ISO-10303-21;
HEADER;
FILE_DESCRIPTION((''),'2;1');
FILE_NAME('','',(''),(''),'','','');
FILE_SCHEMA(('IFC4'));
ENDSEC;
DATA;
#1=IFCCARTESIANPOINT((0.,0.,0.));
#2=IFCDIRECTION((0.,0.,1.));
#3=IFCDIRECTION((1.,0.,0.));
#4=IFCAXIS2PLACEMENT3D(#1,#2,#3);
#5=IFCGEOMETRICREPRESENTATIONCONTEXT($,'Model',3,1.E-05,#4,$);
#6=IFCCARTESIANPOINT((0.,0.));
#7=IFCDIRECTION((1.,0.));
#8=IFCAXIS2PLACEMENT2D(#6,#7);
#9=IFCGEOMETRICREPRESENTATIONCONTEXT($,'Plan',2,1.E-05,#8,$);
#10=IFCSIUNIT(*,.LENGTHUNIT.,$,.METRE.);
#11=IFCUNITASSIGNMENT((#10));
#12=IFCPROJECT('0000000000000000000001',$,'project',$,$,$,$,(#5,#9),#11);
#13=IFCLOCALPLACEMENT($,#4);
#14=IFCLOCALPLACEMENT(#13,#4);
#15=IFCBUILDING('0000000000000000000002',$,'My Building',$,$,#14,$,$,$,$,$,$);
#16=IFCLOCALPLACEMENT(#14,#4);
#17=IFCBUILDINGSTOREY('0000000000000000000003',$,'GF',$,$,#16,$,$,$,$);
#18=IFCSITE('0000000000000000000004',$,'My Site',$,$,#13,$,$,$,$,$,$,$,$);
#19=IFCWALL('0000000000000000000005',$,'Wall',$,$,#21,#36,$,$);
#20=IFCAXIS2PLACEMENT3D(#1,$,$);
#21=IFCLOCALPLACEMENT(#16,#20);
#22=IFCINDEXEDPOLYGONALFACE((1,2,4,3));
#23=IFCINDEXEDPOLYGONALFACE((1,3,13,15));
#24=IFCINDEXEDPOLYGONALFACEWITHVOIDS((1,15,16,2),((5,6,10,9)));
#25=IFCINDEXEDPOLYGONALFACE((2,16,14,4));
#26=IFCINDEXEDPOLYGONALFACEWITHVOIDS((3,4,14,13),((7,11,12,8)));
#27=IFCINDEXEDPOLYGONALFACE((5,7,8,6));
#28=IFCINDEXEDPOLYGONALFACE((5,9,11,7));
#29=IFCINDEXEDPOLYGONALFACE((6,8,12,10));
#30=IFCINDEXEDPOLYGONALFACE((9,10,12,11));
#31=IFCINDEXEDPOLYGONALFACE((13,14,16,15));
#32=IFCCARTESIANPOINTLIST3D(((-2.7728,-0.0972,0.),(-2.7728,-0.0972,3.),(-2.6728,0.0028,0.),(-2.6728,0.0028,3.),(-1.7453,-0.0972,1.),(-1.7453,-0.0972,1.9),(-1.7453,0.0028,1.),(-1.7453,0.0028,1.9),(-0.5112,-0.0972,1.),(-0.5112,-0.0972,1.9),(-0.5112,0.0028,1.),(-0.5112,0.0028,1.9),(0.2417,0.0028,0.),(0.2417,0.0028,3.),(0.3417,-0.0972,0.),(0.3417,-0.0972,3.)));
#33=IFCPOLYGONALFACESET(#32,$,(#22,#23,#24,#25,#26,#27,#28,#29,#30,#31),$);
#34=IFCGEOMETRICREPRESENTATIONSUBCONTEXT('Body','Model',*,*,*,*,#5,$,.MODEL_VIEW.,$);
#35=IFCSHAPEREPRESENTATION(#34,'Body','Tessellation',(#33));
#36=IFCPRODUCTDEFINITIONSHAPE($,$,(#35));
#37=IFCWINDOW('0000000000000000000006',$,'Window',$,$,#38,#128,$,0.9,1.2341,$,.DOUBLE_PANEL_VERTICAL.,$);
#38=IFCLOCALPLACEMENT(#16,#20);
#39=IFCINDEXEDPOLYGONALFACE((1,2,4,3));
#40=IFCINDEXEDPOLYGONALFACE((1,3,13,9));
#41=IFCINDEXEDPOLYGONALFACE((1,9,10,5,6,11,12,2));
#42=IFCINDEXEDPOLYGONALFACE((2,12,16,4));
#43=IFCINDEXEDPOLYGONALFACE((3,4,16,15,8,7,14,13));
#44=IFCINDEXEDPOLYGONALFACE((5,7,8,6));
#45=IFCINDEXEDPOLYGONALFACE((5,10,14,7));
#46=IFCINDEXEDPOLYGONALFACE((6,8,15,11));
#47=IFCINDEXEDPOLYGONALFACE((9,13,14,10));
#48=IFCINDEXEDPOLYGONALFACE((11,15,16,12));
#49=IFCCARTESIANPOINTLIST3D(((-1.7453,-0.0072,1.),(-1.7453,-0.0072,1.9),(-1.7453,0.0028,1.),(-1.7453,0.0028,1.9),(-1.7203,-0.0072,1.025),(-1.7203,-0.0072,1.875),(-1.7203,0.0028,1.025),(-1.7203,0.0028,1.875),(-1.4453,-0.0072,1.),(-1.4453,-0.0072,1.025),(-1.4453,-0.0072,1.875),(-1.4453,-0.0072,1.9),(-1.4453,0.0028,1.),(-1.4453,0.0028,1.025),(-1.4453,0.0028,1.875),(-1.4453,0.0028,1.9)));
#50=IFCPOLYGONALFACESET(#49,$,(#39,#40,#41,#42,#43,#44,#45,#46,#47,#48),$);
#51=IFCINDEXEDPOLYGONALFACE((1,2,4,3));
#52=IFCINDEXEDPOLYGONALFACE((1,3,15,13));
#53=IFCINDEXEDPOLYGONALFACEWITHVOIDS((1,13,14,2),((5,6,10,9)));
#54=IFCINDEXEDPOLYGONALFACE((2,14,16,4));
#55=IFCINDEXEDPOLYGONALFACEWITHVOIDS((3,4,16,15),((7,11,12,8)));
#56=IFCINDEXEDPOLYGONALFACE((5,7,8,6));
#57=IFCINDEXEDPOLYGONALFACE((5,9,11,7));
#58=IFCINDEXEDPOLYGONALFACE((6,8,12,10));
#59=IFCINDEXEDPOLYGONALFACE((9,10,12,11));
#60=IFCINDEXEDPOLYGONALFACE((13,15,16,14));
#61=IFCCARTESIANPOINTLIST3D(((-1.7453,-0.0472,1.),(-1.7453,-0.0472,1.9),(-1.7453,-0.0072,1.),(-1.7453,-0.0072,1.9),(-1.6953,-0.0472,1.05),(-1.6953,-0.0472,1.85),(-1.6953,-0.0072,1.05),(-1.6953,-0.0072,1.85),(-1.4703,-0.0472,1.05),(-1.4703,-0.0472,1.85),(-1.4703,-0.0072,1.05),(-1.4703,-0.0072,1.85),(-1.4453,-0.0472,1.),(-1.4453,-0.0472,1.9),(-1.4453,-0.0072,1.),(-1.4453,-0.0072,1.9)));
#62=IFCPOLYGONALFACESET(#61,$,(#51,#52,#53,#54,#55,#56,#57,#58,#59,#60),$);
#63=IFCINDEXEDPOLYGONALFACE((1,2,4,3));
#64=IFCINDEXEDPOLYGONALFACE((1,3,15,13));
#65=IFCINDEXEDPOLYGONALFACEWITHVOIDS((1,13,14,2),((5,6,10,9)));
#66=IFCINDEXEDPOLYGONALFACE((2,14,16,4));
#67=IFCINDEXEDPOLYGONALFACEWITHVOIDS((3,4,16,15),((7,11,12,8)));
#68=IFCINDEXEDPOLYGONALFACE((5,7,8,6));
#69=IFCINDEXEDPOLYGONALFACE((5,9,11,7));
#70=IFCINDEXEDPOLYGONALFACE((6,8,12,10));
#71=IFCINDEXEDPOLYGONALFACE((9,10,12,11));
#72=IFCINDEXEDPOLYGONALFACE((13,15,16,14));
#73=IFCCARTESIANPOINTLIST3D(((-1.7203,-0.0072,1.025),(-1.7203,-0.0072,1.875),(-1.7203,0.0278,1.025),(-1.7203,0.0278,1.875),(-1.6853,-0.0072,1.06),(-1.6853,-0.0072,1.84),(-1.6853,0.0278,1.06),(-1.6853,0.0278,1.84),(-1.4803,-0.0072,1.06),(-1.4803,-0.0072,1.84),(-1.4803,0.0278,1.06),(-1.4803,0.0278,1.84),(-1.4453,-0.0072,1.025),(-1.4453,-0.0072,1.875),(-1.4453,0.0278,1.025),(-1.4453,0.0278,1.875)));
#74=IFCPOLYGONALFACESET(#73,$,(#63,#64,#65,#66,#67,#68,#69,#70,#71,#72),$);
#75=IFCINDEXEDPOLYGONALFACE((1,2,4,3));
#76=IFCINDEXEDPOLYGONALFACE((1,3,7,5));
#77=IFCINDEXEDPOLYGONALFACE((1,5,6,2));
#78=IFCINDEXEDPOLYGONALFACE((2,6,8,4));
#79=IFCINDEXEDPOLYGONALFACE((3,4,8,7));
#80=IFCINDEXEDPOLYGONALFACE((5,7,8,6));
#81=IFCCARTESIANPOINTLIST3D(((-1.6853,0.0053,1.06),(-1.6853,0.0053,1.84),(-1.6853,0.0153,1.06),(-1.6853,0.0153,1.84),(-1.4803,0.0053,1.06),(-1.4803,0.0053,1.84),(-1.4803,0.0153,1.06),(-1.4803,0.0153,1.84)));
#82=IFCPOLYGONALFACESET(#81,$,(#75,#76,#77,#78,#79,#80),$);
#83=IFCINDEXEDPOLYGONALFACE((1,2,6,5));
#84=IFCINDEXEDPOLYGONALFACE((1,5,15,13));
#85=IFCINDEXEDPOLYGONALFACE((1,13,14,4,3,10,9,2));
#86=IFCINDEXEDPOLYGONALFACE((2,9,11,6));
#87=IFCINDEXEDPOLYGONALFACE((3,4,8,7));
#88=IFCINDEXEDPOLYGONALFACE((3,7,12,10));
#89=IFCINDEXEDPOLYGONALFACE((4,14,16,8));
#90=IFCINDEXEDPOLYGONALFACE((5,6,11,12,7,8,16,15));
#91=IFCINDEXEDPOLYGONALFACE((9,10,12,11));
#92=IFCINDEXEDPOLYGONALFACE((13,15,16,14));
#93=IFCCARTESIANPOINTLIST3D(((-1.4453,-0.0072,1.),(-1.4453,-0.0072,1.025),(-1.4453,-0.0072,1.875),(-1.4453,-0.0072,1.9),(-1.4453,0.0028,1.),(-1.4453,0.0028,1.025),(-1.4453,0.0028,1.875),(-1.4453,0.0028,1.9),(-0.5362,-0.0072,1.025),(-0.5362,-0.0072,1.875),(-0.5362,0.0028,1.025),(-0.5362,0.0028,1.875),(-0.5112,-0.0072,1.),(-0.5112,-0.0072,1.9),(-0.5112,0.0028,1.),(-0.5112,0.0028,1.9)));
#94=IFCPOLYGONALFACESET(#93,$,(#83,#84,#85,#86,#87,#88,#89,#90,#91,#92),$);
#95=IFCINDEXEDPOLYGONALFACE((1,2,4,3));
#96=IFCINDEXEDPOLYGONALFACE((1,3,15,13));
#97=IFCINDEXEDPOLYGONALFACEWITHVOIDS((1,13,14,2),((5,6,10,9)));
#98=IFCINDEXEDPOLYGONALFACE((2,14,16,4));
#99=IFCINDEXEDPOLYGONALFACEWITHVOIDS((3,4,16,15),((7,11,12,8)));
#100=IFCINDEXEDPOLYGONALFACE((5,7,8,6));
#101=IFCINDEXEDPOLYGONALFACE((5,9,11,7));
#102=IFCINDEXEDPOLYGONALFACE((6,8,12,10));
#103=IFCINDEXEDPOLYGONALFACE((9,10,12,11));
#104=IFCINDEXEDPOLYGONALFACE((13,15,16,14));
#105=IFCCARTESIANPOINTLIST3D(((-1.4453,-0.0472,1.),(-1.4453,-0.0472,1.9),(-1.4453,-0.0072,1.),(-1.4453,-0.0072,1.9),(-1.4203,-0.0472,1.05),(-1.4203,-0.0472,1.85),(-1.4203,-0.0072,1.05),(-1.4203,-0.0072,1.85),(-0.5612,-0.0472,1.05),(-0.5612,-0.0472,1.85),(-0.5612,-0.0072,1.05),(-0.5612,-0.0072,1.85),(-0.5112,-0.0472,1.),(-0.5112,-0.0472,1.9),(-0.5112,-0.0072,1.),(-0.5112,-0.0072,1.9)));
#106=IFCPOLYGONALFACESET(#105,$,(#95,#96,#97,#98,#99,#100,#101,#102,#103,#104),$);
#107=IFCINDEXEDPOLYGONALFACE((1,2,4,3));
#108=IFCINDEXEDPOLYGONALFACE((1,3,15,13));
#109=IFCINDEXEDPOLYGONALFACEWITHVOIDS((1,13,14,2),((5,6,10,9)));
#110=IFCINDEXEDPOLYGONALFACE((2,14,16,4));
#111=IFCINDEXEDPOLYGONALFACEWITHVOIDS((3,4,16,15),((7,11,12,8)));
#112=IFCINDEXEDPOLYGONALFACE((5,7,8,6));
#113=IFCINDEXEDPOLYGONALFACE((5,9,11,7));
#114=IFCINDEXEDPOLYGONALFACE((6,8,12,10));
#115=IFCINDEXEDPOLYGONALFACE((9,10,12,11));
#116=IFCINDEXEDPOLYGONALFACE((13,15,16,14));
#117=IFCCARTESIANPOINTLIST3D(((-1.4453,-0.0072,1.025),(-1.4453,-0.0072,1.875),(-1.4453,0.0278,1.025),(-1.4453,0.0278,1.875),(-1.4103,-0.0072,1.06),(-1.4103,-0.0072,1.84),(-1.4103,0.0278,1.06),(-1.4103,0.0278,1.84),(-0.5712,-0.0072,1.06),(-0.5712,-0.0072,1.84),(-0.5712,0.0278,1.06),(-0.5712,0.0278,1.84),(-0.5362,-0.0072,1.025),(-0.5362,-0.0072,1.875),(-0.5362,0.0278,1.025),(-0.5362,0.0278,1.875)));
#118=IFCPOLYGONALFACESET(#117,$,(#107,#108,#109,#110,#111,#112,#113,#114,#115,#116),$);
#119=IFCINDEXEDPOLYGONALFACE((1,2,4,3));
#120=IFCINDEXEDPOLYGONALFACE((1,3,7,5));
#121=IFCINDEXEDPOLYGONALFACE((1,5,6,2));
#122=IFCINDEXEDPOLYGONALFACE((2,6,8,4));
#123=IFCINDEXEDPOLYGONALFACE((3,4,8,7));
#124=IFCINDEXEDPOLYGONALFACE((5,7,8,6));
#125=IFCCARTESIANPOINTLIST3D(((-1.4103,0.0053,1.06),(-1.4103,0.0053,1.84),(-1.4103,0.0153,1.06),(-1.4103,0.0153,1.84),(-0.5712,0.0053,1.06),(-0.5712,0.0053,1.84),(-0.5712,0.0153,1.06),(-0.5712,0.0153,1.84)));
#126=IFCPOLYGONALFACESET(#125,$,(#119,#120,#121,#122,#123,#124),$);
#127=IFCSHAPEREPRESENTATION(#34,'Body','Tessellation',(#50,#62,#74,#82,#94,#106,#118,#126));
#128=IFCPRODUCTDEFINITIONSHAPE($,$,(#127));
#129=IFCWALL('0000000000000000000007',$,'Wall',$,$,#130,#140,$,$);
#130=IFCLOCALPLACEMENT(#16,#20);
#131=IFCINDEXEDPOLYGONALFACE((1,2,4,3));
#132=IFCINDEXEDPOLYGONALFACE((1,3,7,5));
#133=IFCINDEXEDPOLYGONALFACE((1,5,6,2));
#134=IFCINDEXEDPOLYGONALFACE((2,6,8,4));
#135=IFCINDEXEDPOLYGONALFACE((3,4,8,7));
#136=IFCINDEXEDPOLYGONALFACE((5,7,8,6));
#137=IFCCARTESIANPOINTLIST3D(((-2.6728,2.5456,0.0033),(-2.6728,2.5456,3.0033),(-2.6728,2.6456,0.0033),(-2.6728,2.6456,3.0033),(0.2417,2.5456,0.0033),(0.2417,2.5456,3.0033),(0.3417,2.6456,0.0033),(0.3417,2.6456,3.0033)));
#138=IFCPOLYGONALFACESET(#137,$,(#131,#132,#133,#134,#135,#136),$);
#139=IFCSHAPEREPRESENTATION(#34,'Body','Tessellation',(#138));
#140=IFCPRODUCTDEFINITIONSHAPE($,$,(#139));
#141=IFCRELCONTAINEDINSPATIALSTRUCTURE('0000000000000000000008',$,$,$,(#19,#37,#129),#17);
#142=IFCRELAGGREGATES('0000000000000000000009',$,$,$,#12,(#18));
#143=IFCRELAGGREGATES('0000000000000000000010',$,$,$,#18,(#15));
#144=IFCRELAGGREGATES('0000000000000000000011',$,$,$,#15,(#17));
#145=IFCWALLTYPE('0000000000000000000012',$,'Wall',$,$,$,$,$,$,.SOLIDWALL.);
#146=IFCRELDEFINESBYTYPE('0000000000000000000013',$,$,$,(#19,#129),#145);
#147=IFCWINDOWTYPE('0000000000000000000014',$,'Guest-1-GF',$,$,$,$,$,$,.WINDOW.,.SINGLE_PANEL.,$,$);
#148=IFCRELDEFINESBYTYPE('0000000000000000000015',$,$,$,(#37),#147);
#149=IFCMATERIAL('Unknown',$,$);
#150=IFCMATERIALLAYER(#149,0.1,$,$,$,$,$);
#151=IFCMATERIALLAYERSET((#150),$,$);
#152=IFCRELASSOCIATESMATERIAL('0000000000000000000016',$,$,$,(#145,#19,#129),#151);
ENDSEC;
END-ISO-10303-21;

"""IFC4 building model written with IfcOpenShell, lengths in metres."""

from ifc_helpers import new_model, entity, si_unit, frame, origin_with_axes, origin_2d_with_axis, place, context, subcontext, project, spatial, line, indexed_curve, outline, extrude, shape, source, transform, mapped, material, layer, layer_set, layer_usage, type_object, type_shapes, element, fill, save


model = new_model("IFC4")

# Units and contexts
model_context = context("Model", 3, precision=1e-05, world=origin_with_axes())
plan_context = context("Plan", 2, precision=1e-05, world=origin_2d_with_axis())
body_context_1 = subcontext(model_context, "Body", "Model", "MODEL_VIEW")
body_context_2 = subcontext(plan_context, "Body", "Plan", "PLAN_VIEW")
ifc_project = project(units=[si_unit("LENGTHUNIT", "METRE")], contexts=[model_context, plan_context])

# Site, building, storey
site_placement = place(None, origin_with_axes())
site = spatial("IfcSite", under=ifc_project, at=site_placement, Name="My Site")
building_placement = place(site_placement, origin_with_axes())
building = spatial("IfcBuilding", under=site, at=building_placement, Name="My Building")
storey_placement = place(building_placement, origin_with_axes())
storey = spatial("IfcBuildingStorey", under=building, at=storey_placement, Name="GF")

# Shared definitions
ifc_material_1 = material(Name="Unknown")

# Shared definitions
ifc_layer_1 = layer(ifc_material_1, 0.1)
ifc_layer_set_1 = layer_set([ifc_layer_1])
wall_type = type_object("IfcWallType", Name="Wall", PredefinedType="SOLIDWALL", material=ifc_layer_set_1)

# Wall, opening, window
ifc_layer_usage_1 = layer_usage(ifc_layer_set_1, "AXIS2", "POSITIVE", 0.0)
wall_1_placement = place(storey_placement, frame((-2.7728, -0.0972, 0.0), z_axis=(0.0, 0.0, 1.0), x_axis=(1.0, 0.0, 0.0)))
wall_1 = element("IfcWall", 1, at=wall_1_placement, inside=storey, type_object=wall_type, material=ifc_layer_usage_1, Name="Wall", context=body_context_1, shape_type="SweptSolid", body=[
    extrude(outline(indexed_curve([(0.0, 0.0), (0.1, 0.1), (3.0145, 0.1), (3.1145, 0.0)], segments=[line(1, 2, 3, 4, 1)])), origin_with_axes(), (0.0, 0.0, 1.0), 3.0),
])
shared_shape_1 = source(origin_with_axes(), body_context_1, "Body", "SweptSolid", [
    extrude(outline(indexed_curve([(0.0, 0.0), (1.2341, 0.0), (1.2341, 0.9), (0.0, 0.9)], segments=[line(1, 2, 3, 4, 1)])), frame((0.0, -0.6, 0.0), z_axis=(0.0, -1.0, 0.0), x_axis=(1.0, 0.0, 0.0)), (0.0, 0.0, -1.0), 1.2),
])
opening_1_placement = place(wall_1_placement, frame((1.0275, 0.0, 1.0), z_axis=(0.0, 0.0, 1.0), x_axis=(1.0, 0.0, 0.0)))
opening_1 = element("IfcOpeningElement", 2, at=opening_1_placement, cuts=wall_1, PredefinedType="OPENING", context=body_context_1, shape_type="MappedRepresentation", body=[
    mapped(shared_shape_1, transform((0.0, 0.0, 0.0), x_axis=(1.0, 0.0, 0.0), y_axis=(0.0, 1.0, 0.0), z_axis=(0.0, 0.0, 1.0), scale=1.0)),
])
window_type_1 = type_object("IfcWindowType", Name="Guest-1-GF", PartitioningType="SINGLE_PANEL", PredefinedType="WINDOW")
shared_shape_2 = source(origin_with_axes(), body_context_1, "Body", "SweptSolid", [
    extrude(outline(indexed_curve([(0.3, 0.0), (0.0, 0.0), (0.0, 0.9), (0.3, 0.9), (0.3, 0.875), (0.025, 0.875), (0.025, 0.025), (0.3, 0.025)], segments=[line(1, 2, 3, 4, 5, 6, 7, 8, 1)])), frame((0.0, 0.09, 0.0), z_axis=(0.0, -1.0, 0.0), x_axis=(1.0, 0.0, 0.0)), (0.0, 0.0, -1.0), 0.01),
    extrude(outline(indexed_curve([(0.0, 0.0), (0.3, 0.0), (0.3, 0.9), (0.0, 0.9)], segments=[line(1, 2, 3, 4, 1)]), holes=[indexed_curve([(0.05, 0.05), (0.275, 0.05), (0.275, 0.85), (0.05, 0.85)], segments=[line(1, 2, 3, 4, 1)])]), frame((0.0, 0.05, 0.0), z_axis=(0.0, -1.0, 0.0), x_axis=(1.0, 0.0, 0.0)), (0.0, 0.0, -1.0), 0.04),
    extrude(outline(indexed_curve([(0.0, 0.0), (0.275, 0.0), (0.275, 0.85), (0.0, 0.85)], segments=[line(1, 2, 3, 4, 1)]), holes=[indexed_curve([(0.035, 0.035), (0.24, 0.035), (0.24, 0.815), (0.035, 0.815)], segments=[line(1, 2, 3, 4, 1)])]), frame((0.025, 0.09, 0.025), z_axis=(0.0, -1.0, 0.0), x_axis=(1.0, 0.0, 0.0)), (0.0, 0.0, -1.0), 0.035),
    extrude(outline(indexed_curve([(0.035, 0.035), (0.24, 0.035), (0.24, 0.815), (0.035, 0.815)], segments=[line(1, 2, 3, 4, 1)])), frame((0.025, 0.1025, 0.025), z_axis=(0.0, -1.0, 0.0), x_axis=(1.0, 0.0, 0.0)), (0.0, 0.0, -1.0), 0.01),
    extrude(outline(indexed_curve([(0.0, 0.9), (0.9341, 0.9), (0.9341, 0.0), (0.0, 0.0), (0.0, 0.025), (0.9091, 0.025), (0.9091, 0.875), (0.0, 0.875)], segments=[line(1, 2, 3, 4, 5, 6, 7, 8, 1)])), frame((0.3, 0.09, 0.0), z_axis=(0.0, -1.0, 0.0), x_axis=(1.0, 0.0, 0.0)), (0.0, 0.0, -1.0), 0.01),
    extrude(outline(indexed_curve([(0.0, 0.0), (0.9341, 0.0), (0.9341, 0.9), (0.0, 0.9)], segments=[line(1, 2, 3, 4, 1)]), holes=[indexed_curve([(0.025, 0.05), (0.8841, 0.05), (0.8841, 0.85), (0.025, 0.85)], segments=[line(1, 2, 3, 4, 1)])]), frame((0.3, 0.05, 0.0), z_axis=(0.0, -1.0, 0.0), x_axis=(1.0, 0.0, 0.0)), (0.0, 0.0, -1.0), 0.04),
    extrude(outline(indexed_curve([(0.0, 0.0), (0.9091, 0.0), (0.9091, 0.85), (0.0, 0.85)], segments=[line(1, 2, 3, 4, 1)]), holes=[indexed_curve([(0.035, 0.035), (0.8741, 0.035), (0.8741, 0.815), (0.035, 0.815)], segments=[line(1, 2, 3, 4, 1)])]), frame((0.3, 0.09, 0.025), z_axis=(0.0, -1.0, 0.0), x_axis=(1.0, 0.0, 0.0)), (0.0, 0.0, -1.0), 0.035),
    extrude(outline(indexed_curve([(0.035, 0.035), (0.8741, 0.035), (0.8741, 0.815), (0.035, 0.815)], segments=[line(1, 2, 3, 4, 1)])), frame((0.3, 0.1025, 0.025), z_axis=(0.0, -1.0, 0.0), x_axis=(1.0, 0.0, 0.0)), (0.0, 0.0, -1.0), 0.01),
])
shared_shape_3 = source(origin_with_axes(), body_context_2, "Body", "Curve2D", [
    entity("IfcIndexedPolyCurve", entity("IfcCartesianPointList2D", [[0.05, 0.05], [0.275, 0.05]])),
    entity("IfcIndexedPolyCurve", entity("IfcCartesianPointList2D", [[0.0, 0.1], [0.025, 0.1], [0.025, 0.09], [0.05, 0.09], [0.05, 0.05], [0.0, 0.05]]), [entity("IfcLineIndex", [1, 2, 3, 4, 5, 6, 1])]),
    entity("IfcIndexedPolyCurve", entity("IfcCartesianPointList2D", [[0.3, 0.1], [0.3, 0.1], [0.3, 0.09], [0.275, 0.09], [0.275, 0.05], [0.3, 0.05]])),
    entity("IfcIndexedPolyCurve", entity("IfcCartesianPointList2D", [[0.025, 0.09], [0.06, 0.09], [0.06, 0.125], [0.025, 0.125]]), [entity("IfcLineIndex", [1, 2, 3, 4, 1])]),
    entity("IfcIndexedPolyCurve", entity("IfcCartesianPointList2D", [[0.3, 0.09], [0.265, 0.09], [0.265, 0.125], [0.3, 0.125]]), [entity("IfcLineIndex", [1, 2, 3, 4, 1])]),
    entity("IfcIndexedPolyCurve", entity("IfcCartesianPointList2D", [[0.06, 0.09], [0.265, 0.09]])),
    entity("IfcIndexedPolyCurve", entity("IfcCartesianPointList2D", [[0.06, 0.125], [0.265, 0.125]])),
    entity("IfcIndexedPolyCurve", entity("IfcCartesianPointList2D", [[0.06, 0.1075], [0.265, 0.1075]])),
    entity("IfcIndexedPolyCurve", entity("IfcCartesianPointList2D", [[0.325, 0.05], [1.1841, 0.05]])),
    entity("IfcIndexedPolyCurve", entity("IfcCartesianPointList2D", [[0.3, 0.1], [0.3, 0.1], [0.3, 0.09], [0.325, 0.09], [0.325, 0.05], [0.3, 0.05]])),
    entity("IfcIndexedPolyCurve", entity("IfcCartesianPointList2D", [[1.2341, 0.1], [1.2091, 0.1], [1.2091, 0.09], [1.1841, 0.09], [1.1841, 0.05], [1.2341, 0.05]]), [entity("IfcLineIndex", [1, 2, 3, 4, 5, 6, 1])]),
    entity("IfcIndexedPolyCurve", entity("IfcCartesianPointList2D", [[0.3, 0.09], [0.335, 0.09], [0.335, 0.125], [0.3, 0.125]]), [entity("IfcLineIndex", [1, 2, 3, 4, 1])]),
    entity("IfcIndexedPolyCurve", entity("IfcCartesianPointList2D", [[1.2091, 0.09], [1.1741, 0.09], [1.1741, 0.125], [1.2091, 0.125]]), [entity("IfcLineIndex", [1, 2, 3, 4, 1])]),
    entity("IfcIndexedPolyCurve", entity("IfcCartesianPointList2D", [[0.335, 0.09], [1.1741, 0.09]])),
    entity("IfcIndexedPolyCurve", entity("IfcCartesianPointList2D", [[0.335, 0.125], [1.1741, 0.125]])),
    entity("IfcIndexedPolyCurve", entity("IfcCartesianPointList2D", [[0.335, 0.1075], [1.1741, 0.1075]])),
])
type_shapes(window_type_1, [shared_shape_2, shared_shape_3])
window_1_placement = place(opening_1_placement, frame((0.0, 0.0, 0.0), z_axis=(0.0, 0.0, 1.0), x_axis=(1.0, 0.0, 0.0)))
window_1 = element("IfcWindow", 3, at=window_1_placement, inside=storey, type_object=window_type_1, Name="Window", OverallHeight=0.9, OverallWidth=1.2341, PartitioningType="DOUBLE_PANEL_VERTICAL", shapes=[
    shape(body_context_1, "Body", "MappedRepresentation", [mapped(shared_shape_2, transform((0.0, 0.0, 0.0), x_axis=(1.0, 0.0, 0.0), y_axis=(0.0, 1.0, 0.0), z_axis=(0.0, 0.0, 1.0), scale=1.0))]),
    shape(body_context_2, "Body", "MappedRepresentation", [mapped(shared_shape_3, transform((0.0, 0.0, 0.0), x_axis=(1.0, 0.0, 0.0), y_axis=(0.0, 1.0, 0.0), z_axis=(0.0, 0.0, 1.0), scale=1.0))]),
])
fill(opening_1, window_1)

# Wall
ifc_layer_usage_2 = layer_usage(ifc_layer_set_1, "AXIS2", "POSITIVE", 0.0)
wall_2_placement = place(storey_placement, frame((-2.7728, 2.5456, 0.0033), z_axis=(0.0, 0.0, 1.0), x_axis=(1.0, 0.0, 0.0)))
element("IfcWall", 4, at=wall_2_placement, inside=storey, type_object=wall_type, material=ifc_layer_usage_2, Name="Wall", context=body_context_1, shape_type="SweptSolid", body=[
    extrude(outline(indexed_curve([(0.1, 0.0), (0.1, 0.1), (3.1145, 0.1), (3.0145, 0.0)], segments=[line(1, 2, 3, 4, 1)])), origin_with_axes(), (0.0, 0.0, 1.0), 3.0),
])

save(model, "model.ifc")
